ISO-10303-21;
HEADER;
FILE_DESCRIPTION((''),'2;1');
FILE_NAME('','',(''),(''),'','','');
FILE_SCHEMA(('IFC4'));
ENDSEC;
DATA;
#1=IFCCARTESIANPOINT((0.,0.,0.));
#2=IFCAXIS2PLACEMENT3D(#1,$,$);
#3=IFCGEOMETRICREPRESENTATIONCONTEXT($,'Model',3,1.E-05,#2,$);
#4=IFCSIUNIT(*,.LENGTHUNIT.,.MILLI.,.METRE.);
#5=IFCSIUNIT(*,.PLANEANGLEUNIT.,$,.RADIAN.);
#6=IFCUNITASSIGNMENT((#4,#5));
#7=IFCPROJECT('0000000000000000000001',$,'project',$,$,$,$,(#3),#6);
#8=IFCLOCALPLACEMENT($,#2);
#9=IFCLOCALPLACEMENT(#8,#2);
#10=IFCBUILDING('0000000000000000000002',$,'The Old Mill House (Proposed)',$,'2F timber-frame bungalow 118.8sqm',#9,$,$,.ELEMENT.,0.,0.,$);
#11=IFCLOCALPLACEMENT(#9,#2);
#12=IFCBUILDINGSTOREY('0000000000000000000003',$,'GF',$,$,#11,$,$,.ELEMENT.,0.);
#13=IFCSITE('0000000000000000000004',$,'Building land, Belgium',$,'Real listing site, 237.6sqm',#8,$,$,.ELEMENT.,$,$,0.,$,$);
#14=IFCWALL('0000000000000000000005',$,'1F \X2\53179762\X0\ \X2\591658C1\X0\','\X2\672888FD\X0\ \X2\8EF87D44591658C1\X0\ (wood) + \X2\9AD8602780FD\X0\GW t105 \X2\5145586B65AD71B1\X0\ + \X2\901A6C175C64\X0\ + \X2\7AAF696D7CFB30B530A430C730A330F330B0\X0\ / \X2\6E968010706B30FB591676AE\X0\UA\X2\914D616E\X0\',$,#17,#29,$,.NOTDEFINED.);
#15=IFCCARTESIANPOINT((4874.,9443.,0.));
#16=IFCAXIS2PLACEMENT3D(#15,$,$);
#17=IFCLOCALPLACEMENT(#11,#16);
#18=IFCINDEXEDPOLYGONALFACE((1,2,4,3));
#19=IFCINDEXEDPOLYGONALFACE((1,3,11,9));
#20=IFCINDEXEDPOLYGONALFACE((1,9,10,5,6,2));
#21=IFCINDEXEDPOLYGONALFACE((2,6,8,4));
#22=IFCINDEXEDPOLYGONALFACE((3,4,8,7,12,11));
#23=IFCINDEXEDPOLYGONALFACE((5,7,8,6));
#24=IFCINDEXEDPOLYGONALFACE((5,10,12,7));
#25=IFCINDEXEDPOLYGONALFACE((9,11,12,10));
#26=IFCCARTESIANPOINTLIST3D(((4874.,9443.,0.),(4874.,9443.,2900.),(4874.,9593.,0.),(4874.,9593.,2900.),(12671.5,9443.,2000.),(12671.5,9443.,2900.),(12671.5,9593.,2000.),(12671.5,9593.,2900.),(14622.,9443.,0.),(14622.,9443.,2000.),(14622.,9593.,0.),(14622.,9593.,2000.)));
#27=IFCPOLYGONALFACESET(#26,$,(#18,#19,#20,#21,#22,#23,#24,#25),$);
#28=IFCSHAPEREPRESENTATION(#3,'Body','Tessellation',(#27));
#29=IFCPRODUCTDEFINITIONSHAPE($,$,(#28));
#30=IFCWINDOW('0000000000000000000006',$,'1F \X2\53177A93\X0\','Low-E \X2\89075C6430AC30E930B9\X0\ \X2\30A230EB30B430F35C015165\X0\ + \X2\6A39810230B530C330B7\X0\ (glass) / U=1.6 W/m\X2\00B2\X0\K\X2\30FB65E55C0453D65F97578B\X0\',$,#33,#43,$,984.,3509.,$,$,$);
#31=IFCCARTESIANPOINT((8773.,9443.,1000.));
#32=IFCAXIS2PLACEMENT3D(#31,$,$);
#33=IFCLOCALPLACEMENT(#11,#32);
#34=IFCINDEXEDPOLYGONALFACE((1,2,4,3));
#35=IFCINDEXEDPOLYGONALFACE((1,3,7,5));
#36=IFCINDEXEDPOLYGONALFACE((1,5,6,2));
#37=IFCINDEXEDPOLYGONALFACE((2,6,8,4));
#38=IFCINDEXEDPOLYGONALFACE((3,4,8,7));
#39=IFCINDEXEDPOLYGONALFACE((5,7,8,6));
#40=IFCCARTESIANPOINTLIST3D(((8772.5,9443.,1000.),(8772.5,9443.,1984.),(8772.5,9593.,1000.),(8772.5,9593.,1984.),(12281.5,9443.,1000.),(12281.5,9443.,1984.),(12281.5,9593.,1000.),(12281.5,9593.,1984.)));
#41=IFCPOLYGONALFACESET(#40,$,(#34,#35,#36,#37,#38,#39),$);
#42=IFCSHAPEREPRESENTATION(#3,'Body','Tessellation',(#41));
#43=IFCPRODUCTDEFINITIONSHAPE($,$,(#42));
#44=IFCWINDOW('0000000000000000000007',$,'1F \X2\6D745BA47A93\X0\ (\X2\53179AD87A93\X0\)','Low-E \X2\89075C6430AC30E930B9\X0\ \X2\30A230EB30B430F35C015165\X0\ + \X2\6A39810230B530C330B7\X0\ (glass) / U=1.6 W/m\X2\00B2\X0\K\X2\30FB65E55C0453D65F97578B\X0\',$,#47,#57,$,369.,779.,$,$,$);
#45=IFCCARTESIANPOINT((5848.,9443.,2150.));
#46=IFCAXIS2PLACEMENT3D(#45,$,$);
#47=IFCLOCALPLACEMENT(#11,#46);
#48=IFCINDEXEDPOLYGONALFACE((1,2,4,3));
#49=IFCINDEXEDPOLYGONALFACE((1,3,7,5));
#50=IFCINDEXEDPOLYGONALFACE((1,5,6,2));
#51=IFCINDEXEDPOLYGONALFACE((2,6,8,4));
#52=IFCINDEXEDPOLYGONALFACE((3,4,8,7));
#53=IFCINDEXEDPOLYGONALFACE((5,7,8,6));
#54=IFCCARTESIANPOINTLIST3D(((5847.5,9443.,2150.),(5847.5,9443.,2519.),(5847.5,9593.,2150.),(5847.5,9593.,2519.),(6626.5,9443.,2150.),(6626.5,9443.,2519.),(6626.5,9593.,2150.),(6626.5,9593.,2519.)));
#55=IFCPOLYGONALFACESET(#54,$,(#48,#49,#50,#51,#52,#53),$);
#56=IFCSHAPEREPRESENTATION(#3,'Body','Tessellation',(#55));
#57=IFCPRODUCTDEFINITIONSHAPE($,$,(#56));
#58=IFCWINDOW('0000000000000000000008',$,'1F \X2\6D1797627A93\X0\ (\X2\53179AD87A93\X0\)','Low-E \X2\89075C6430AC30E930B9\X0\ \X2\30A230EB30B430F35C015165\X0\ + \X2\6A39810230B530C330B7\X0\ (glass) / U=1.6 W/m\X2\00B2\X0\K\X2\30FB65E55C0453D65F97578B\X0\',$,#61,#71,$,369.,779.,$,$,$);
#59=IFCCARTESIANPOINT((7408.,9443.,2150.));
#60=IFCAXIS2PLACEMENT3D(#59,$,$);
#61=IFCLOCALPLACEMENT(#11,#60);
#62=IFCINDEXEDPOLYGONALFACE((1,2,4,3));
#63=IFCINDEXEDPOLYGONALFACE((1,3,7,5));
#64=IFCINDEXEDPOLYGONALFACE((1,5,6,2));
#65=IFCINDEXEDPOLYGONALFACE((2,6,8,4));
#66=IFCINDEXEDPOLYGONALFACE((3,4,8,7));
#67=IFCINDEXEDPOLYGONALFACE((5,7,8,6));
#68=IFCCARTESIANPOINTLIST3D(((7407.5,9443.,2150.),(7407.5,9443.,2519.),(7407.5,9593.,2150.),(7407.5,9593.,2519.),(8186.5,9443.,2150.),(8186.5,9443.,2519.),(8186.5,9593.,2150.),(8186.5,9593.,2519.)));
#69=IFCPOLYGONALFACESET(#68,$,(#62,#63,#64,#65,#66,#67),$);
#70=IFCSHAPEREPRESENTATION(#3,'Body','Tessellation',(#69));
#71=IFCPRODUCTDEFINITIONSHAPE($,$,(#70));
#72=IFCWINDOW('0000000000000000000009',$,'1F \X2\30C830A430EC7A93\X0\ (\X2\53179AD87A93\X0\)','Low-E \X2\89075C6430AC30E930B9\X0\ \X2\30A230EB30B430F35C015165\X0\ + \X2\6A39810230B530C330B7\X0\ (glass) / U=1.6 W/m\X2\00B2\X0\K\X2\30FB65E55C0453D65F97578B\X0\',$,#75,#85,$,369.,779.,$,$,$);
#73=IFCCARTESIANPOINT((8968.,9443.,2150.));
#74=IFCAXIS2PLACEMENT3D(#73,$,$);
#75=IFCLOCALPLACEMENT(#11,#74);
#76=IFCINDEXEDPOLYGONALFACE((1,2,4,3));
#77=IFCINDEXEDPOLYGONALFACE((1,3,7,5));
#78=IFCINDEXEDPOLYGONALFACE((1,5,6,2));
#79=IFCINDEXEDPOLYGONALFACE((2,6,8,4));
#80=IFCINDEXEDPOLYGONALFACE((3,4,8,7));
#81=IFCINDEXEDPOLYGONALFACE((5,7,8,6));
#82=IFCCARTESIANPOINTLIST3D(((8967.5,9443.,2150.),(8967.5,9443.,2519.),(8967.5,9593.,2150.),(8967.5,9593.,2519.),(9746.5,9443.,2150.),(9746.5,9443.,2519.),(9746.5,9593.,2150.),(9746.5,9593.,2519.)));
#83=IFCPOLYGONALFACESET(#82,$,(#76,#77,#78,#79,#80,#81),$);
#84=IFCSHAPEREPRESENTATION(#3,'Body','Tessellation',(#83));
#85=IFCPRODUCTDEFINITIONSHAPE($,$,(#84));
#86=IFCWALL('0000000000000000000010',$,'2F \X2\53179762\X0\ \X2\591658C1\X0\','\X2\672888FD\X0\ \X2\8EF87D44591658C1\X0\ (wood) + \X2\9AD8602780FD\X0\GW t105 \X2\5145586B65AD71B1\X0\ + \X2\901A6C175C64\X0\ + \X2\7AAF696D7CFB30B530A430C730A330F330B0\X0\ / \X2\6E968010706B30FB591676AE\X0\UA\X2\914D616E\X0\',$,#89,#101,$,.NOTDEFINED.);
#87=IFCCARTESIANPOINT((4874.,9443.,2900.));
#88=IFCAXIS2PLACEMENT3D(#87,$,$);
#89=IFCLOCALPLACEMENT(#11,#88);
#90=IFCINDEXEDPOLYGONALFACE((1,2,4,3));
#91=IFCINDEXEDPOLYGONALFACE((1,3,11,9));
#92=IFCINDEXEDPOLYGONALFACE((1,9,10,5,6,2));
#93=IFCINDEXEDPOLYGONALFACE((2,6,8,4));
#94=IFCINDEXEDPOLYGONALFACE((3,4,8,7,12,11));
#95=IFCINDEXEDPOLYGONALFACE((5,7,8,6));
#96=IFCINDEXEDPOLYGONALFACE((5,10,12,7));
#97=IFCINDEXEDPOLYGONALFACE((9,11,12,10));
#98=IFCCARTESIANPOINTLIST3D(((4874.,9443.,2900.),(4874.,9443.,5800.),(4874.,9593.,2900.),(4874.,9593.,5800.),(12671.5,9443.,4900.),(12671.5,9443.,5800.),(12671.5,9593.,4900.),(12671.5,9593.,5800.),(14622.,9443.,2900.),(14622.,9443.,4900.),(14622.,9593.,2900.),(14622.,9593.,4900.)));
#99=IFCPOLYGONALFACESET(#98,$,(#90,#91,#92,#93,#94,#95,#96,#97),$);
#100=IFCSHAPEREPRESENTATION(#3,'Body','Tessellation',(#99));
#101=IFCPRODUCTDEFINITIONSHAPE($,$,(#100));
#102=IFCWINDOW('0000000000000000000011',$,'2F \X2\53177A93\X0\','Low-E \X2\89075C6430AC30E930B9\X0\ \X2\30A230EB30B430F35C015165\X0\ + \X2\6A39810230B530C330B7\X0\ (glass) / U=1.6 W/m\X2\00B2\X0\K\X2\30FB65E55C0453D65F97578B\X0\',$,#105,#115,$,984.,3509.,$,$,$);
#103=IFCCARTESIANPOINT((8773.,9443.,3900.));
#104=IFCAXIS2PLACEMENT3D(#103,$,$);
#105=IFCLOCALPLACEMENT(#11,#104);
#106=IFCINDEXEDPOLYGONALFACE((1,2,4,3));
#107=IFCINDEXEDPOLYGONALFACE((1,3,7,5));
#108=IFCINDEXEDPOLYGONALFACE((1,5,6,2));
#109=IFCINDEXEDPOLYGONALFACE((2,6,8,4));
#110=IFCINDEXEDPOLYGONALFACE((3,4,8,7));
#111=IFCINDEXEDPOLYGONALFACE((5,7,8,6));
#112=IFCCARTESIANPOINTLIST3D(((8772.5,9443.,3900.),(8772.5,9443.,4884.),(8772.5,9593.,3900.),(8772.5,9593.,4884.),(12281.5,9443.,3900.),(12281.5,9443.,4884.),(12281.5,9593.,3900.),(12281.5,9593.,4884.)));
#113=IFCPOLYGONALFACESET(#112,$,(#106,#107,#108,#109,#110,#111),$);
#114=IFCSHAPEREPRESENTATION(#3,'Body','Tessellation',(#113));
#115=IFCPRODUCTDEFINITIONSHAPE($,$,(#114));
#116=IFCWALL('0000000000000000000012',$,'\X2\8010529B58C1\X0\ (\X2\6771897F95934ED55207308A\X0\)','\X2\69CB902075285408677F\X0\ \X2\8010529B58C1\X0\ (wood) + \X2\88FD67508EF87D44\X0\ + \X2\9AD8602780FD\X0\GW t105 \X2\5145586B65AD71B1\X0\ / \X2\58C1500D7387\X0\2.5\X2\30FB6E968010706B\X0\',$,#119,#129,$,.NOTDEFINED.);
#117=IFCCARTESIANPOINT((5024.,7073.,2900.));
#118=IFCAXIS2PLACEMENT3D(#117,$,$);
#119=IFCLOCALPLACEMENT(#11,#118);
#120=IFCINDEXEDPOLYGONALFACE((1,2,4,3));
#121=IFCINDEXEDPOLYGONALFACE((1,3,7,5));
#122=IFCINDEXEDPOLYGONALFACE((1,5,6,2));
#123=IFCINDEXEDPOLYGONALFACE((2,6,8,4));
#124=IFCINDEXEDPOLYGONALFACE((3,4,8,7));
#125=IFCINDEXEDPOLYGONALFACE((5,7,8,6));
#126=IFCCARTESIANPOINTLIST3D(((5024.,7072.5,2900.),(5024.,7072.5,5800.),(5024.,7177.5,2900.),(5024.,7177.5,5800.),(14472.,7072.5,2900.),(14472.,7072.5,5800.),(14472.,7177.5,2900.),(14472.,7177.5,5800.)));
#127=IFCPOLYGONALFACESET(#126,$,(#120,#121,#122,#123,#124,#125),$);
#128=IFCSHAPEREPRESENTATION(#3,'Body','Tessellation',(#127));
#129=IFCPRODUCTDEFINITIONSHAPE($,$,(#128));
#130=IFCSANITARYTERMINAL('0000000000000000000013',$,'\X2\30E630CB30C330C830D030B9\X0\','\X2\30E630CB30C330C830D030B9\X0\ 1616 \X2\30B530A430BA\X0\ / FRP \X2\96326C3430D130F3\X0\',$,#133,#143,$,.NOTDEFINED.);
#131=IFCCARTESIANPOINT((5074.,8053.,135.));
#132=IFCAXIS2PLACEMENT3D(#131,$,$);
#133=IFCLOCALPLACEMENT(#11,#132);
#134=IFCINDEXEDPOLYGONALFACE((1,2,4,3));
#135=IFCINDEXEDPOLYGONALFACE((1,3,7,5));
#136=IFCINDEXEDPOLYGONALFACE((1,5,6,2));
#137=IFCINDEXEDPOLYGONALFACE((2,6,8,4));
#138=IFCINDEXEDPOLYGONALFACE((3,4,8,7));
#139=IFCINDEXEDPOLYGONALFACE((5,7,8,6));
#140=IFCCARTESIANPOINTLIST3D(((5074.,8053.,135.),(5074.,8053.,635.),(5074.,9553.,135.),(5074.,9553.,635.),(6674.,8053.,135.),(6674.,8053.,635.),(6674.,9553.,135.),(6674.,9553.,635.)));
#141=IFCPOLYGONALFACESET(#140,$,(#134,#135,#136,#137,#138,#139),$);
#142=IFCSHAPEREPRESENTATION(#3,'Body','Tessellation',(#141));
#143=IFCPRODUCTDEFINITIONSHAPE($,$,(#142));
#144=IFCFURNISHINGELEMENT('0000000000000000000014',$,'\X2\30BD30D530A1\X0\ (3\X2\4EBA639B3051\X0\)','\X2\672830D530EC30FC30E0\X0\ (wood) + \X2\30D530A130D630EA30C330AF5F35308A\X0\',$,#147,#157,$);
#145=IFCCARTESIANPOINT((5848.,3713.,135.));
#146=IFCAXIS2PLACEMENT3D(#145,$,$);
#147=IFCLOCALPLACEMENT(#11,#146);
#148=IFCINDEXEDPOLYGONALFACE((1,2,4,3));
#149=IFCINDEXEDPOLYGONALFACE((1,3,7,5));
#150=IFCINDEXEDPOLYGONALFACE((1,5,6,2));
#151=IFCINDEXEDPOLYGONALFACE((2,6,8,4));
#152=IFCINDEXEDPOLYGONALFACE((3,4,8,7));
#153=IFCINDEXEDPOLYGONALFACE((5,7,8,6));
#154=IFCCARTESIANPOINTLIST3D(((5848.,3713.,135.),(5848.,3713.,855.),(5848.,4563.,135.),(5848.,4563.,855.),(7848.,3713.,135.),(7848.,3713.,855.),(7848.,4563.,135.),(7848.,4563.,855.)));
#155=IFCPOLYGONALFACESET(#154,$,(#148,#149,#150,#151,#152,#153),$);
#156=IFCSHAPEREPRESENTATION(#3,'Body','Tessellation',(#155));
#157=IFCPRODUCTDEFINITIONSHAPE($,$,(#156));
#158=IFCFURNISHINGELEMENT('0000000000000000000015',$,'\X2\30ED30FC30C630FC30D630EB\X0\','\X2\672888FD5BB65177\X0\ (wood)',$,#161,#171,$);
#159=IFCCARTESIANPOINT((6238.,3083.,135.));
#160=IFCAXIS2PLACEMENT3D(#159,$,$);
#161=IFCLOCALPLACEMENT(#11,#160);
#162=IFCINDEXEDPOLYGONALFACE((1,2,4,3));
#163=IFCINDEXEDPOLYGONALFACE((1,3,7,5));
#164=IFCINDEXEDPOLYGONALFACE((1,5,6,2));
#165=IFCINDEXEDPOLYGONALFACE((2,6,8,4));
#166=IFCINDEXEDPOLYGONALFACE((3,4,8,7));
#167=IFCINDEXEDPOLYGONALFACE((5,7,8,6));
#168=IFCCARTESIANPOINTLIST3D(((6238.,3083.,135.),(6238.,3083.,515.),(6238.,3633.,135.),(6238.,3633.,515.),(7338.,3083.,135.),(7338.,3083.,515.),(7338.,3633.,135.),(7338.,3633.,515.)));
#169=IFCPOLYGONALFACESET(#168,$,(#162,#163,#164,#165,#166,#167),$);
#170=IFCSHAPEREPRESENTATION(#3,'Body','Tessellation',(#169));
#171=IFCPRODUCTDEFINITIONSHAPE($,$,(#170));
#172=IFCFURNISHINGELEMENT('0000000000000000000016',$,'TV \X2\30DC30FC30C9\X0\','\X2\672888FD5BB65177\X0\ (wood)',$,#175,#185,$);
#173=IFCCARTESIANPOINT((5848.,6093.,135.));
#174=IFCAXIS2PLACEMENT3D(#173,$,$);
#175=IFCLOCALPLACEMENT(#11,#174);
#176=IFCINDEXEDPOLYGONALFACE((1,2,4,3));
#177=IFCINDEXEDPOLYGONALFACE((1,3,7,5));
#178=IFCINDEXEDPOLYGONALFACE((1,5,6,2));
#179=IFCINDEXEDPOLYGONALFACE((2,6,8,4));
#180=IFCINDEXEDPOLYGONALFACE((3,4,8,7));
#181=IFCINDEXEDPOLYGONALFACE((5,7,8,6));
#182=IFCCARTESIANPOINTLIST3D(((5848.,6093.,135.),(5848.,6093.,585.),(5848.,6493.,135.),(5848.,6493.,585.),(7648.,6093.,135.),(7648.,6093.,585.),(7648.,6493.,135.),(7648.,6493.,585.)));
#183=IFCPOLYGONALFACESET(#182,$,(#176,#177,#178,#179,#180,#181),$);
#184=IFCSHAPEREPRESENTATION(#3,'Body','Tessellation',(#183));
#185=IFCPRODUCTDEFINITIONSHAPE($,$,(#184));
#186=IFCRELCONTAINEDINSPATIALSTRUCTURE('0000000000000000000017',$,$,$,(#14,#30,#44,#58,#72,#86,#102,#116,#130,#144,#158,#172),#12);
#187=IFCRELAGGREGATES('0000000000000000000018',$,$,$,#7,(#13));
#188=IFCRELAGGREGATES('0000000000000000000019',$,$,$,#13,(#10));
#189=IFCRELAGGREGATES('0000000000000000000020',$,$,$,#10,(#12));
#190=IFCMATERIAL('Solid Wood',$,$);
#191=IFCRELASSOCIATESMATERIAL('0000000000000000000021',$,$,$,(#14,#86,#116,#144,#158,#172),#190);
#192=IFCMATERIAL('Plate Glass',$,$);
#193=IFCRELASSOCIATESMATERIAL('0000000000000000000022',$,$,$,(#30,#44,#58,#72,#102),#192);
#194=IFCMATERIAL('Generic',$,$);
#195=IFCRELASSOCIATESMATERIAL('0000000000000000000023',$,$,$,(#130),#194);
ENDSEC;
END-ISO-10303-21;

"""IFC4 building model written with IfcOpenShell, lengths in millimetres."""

from ifc_helpers import new_model, si_unit, frame, frame_2d, origin, place, context, project, spatial, rectangle, extrude, material, element, fill, save


model = new_model("IFC4")

# Units and contexts
model_context = context("Model", 3, precision=1e-05, world=origin())
ifc_project = project(units=[si_unit("LENGTHUNIT", "METRE", prefix="MILLI"), si_unit("PLANEANGLEUNIT", "RADIAN")], contexts=[model_context])

# Site, building, storey
site_placement = place(None, origin())
site = spatial("IfcSite", under=ifc_project, at=site_placement, Name="Building land, Belgium", ObjectType="Real listing site, 237.6sqm", CompositionType="ELEMENT", RefElevation=0.0)
building_placement = place(site_placement, origin())
building = spatial("IfcBuilding", under=site, at=building_placement, Name="The Old Mill House (Proposed)", ObjectType="2F timber-frame bungalow 118.8sqm", CompositionType="ELEMENT", ElevationOfRefHeight=0.0, ElevationOfTerrain=0.0)
storey_placement = place(building_placement, origin())
storey = spatial("IfcBuildingStorey", under=building, at=storey_placement, Name="GF", CompositionType="ELEMENT", Elevation=0.0)

# Wall, openings, windows
ifc_material_1 = material(Name="Solid Wood")
wall_1_placement = place(storey_placement, frame((4874.0, 9443.0, 0.0)))
wall_1 = element("IfcWall", 1, at=wall_1_placement, inside=storey, material=ifc_material_1, Name="1F 北面 外壁", Description="木製 軸組外壁 (wood) + 高性能GW t105 充填断熱 + 通気層 + 窯業系サイディング / 準耐火・外皮UA配慮", PredefinedType="NOTDEFINED", context=model_context, shape_type="SweptSolid", body=[
    extrude(rectangle(XDim=9748.0, YDim=150.0, at=frame_2d((4874.0, 75.0))), frame((4874.0, 9443.0, 0.0)), (0.0, 0.0, 1.0), 2900.0),
])
opening_1_placement = place(storey_placement, frame((8773.0, 9443.0, 1000.0)))
opening_1 = element("IfcOpeningElement", 2, at=opening_1_placement, cuts=wall_1, PredefinedType="NOTDEFINED", context=model_context, shape_type="SweptSolid", body=[
    extrude(rectangle(XDim=3509.0, YDim=150.0, at=frame_2d((1754.0, 75.0))), frame((8773.0, 9443.0, 1000.0)), (0.0, 0.0, 1.0), 984.0),
])
opening_2_placement = place(storey_placement, frame((5848.0, 9443.0, 2150.0)))
opening_2 = element("IfcOpeningElement", 3, at=opening_2_placement, cuts=wall_1, PredefinedType="NOTDEFINED", context=model_context, shape_type="SweptSolid", body=[
    extrude(rectangle(XDim=779.0, YDim=150.0, at=frame_2d((389.0, 75.0))), frame((5848.0, 9443.0, 2150.0)), (0.0, 0.0, 1.0), 369.0),
])
opening_3_placement = place(storey_placement, frame((7408.0, 9443.0, 2150.0)))
opening_3 = element("IfcOpeningElement", 4, at=opening_3_placement, cuts=wall_1, PredefinedType="NOTDEFINED", context=model_context, shape_type="SweptSolid", body=[
    extrude(rectangle(XDim=779.0, YDim=150.0, at=frame_2d((389.0, 75.0))), frame((7408.0, 9443.0, 2150.0)), (0.0, 0.0, 1.0), 369.0),
])
opening_4_placement = place(storey_placement, frame((8968.0, 9443.0, 2150.0)))
opening_4 = element("IfcOpeningElement", 5, at=opening_4_placement, cuts=wall_1, PredefinedType="NOTDEFINED", context=model_context, shape_type="SweptSolid", body=[
    extrude(rectangle(XDim=779.0, YDim=150.0, at=frame_2d((389.0, 75.0))), frame((8968.0, 9443.0, 2150.0)), (0.0, 0.0, 1.0), 369.0),
])
ifc_material_2 = material(Name="Plate Glass")
window_1_placement = place(storey_placement, frame((8773.0, 9443.0, 1000.0)))
window_1 = element("IfcWindow", 6, at=window_1_placement, inside=storey, material=ifc_material_2, Name="1F 北窓", Description="Low-E 複層ガラス アルゴン封入 + 樹脂サッシ (glass) / U=1.6 W/m²K・日射取得型", OverallHeight=984.0, OverallWidth=3509.0, context=model_context, shape_type="SweptSolid", body=[
    extrude(rectangle(XDim=3509.0, YDim=150.0, at=frame_2d((1754.0, 75.0))), frame((8773.0, 9443.0, 1000.0)), (0.0, 0.0, 1.0), 984.0),
])
fill(opening_1, window_1)
window_2_placement = place(storey_placement, frame((5848.0, 9443.0, 2150.0)))
window_2 = element("IfcWindow", 7, at=window_2_placement, inside=storey, material=ifc_material_2, Name="1F 浴室窓 (北高窓)", Description="Low-E 複層ガラス アルゴン封入 + 樹脂サッシ (glass) / U=1.6 W/m²K・日射取得型", OverallHeight=369.0, OverallWidth=779.0, context=model_context, shape_type="SweptSolid", body=[
    extrude(rectangle(XDim=779.0, YDim=150.0, at=frame_2d((389.0, 75.0))), frame((5848.0, 9443.0, 2150.0)), (0.0, 0.0, 1.0), 369.0),
])
fill(opening_2, window_2)
window_3_placement = place(storey_placement, frame((7408.0, 9443.0, 2150.0)))
window_3 = element("IfcWindow", 8, at=window_3_placement, inside=storey, material=ifc_material_2, Name="1F 洗面窓 (北高窓)", Description="Low-E 複層ガラス アルゴン封入 + 樹脂サッシ (glass) / U=1.6 W/m²K・日射取得型", OverallHeight=369.0, OverallWidth=779.0, context=model_context, shape_type="SweptSolid", body=[
    extrude(rectangle(XDim=779.0, YDim=150.0, at=frame_2d((389.0, 75.0))), frame((7408.0, 9443.0, 2150.0)), (0.0, 0.0, 1.0), 369.0),
])
fill(opening_3, window_3)
window_4_placement = place(storey_placement, frame((8968.0, 9443.0, 2150.0)))
window_4 = element("IfcWindow", 9, at=window_4_placement, inside=storey, material=ifc_material_2, Name="1F トイレ窓 (北高窓)", Description="Low-E 複層ガラス アルゴン封入 + 樹脂サッシ (glass) / U=1.6 W/m²K・日射取得型", OverallHeight=369.0, OverallWidth=779.0, context=model_context, shape_type="SweptSolid", body=[
    extrude(rectangle(XDim=779.0, YDim=150.0, at=frame_2d((389.0, 75.0))), frame((8968.0, 9443.0, 2150.0)), (0.0, 0.0, 1.0), 369.0),
])
fill(opening_4, window_4)

# Wall, opening, window
wall_2_placement = place(storey_placement, frame((4874.0, 9443.0, 2900.0)))
wall_2 = element("IfcWall", 10, at=wall_2_placement, inside=storey, material=ifc_material_1, Name="2F 北面 外壁", Description="木製 軸組外壁 (wood) + 高性能GW t105 充填断熱 + 通気層 + 窯業系サイディング / 準耐火・外皮UA配慮", PredefinedType="NOTDEFINED", context=model_context, shape_type="SweptSolid", body=[
    extrude(rectangle(XDim=9748.0, YDim=150.0, at=frame_2d((4874.0, 75.0))), frame((4874.0, 9443.0, 2900.0)), (0.0, 0.0, 1.0), 2900.0),
])
opening_5_placement = place(storey_placement, frame((8773.0, 9443.0, 3900.0)))
opening_5 = element("IfcOpeningElement", 11, at=opening_5_placement, cuts=wall_2, PredefinedType="NOTDEFINED", context=model_context, shape_type="SweptSolid", body=[
    extrude(rectangle(XDim=3509.0, YDim=150.0, at=frame_2d((1754.0, 75.0))), frame((8773.0, 9443.0, 3900.0)), (0.0, 0.0, 1.0), 984.0),
])
window_5_placement = place(storey_placement, frame((8773.0, 9443.0, 3900.0)))
window_5 = element("IfcWindow", 12, at=window_5_placement, inside=storey, material=ifc_material_2, Name="2F 北窓", Description="Low-E 複層ガラス アルゴン封入 + 樹脂サッシ (glass) / U=1.6 W/m²K・日射取得型", OverallHeight=984.0, OverallWidth=3509.0, context=model_context, shape_type="SweptSolid", body=[
    extrude(rectangle(XDim=3509.0, YDim=150.0, at=frame_2d((1754.0, 75.0))), frame((8773.0, 9443.0, 3900.0)), (0.0, 0.0, 1.0), 984.0),
])
fill(opening_5, window_5)

# Wall
wall_3_placement = place(storey_placement, frame((5024.0, 7073.0, 2900.0)))
element("IfcWall", 13, at=wall_3_placement, inside=storey, material=ifc_material_1, Name="耐力壁 (東西間仕切り)", Description="構造用合板 耐力壁 (wood) + 製材軸組 + 高性能GW t105 充填断熱 / 壁倍率2.5・準耐火", PredefinedType="NOTDEFINED", context=model_context, shape_type="SweptSolid", body=[
    extrude(rectangle(XDim=9448.0, YDim=105.0, at=frame_2d((4724.0, 52.0))), frame((5024.0, 7073.0, 2900.0)), (0.0, 0.0, 1.0), 2900.0),
])

# Sanitary terminal
ifc_material_3 = material(Name="Generic")
sanitary_terminal_placement = place(storey_placement, frame((5074.0, 8053.0, 135.0)))
element("IfcSanitaryTerminal", 14, at=sanitary_terminal_placement, inside=storey, material=ifc_material_3, Name="ユニットバス", Description="ユニットバス 1616 サイズ / FRP 防水パン", PredefinedType="NOTDEFINED", context=model_context, shape_type="SweptSolid", body=[
    extrude(rectangle(XDim=1600.0, YDim=1500.0, at=frame_2d((800.0, 750.0))), frame((5074.0, 8053.0, 135.0)), (0.0, 0.0, 1.0), 500.0),
])

# Furnishing elements
furnishing_1_placement = place(storey_placement, frame((5848.0, 3713.0, 135.0)))
element("IfcFurnishingElement", 15, at=furnishing_1_placement, inside=storey, material=ifc_material_1, Name="ソファ (3人掛け)", Description="木フレーム (wood) + ファブリック張り", context=model_context, shape_type="SweptSolid", body=[
    extrude(rectangle(XDim=2000.0, YDim=850.0, at=frame_2d((1000.0, 425.0))), frame((5848.0, 3713.0, 135.0)), (0.0, 0.0, 1.0), 720.0),
])
furnishing_2_placement = place(storey_placement, frame((6238.0, 3083.0, 135.0)))
element("IfcFurnishingElement", 16, at=furnishing_2_placement, inside=storey, material=ifc_material_1, Name="ローテーブル", Description="木製家具 (wood)", context=model_context, shape_type="SweptSolid", body=[
    extrude(rectangle(XDim=1100.0, YDim=550.0, at=frame_2d((550.0, 275.0))), frame((6238.0, 3083.0, 135.0)), (0.0, 0.0, 1.0), 380.0),
])
furnishing_3_placement = place(storey_placement, frame((5848.0, 6093.0, 135.0)))
element("IfcFurnishingElement", 17, at=furnishing_3_placement, inside=storey, material=ifc_material_1, Name="TV ボード", Description="木製家具 (wood)", context=model_context, shape_type="SweptSolid", body=[
    extrude(rectangle(XDim=1800.0, YDim=400.0, at=frame_2d((900.0, 200.0))), frame((5848.0, 6093.0, 135.0)), (0.0, 0.0, 1.0), 450.0),
])

save(model, "model.ifc")
